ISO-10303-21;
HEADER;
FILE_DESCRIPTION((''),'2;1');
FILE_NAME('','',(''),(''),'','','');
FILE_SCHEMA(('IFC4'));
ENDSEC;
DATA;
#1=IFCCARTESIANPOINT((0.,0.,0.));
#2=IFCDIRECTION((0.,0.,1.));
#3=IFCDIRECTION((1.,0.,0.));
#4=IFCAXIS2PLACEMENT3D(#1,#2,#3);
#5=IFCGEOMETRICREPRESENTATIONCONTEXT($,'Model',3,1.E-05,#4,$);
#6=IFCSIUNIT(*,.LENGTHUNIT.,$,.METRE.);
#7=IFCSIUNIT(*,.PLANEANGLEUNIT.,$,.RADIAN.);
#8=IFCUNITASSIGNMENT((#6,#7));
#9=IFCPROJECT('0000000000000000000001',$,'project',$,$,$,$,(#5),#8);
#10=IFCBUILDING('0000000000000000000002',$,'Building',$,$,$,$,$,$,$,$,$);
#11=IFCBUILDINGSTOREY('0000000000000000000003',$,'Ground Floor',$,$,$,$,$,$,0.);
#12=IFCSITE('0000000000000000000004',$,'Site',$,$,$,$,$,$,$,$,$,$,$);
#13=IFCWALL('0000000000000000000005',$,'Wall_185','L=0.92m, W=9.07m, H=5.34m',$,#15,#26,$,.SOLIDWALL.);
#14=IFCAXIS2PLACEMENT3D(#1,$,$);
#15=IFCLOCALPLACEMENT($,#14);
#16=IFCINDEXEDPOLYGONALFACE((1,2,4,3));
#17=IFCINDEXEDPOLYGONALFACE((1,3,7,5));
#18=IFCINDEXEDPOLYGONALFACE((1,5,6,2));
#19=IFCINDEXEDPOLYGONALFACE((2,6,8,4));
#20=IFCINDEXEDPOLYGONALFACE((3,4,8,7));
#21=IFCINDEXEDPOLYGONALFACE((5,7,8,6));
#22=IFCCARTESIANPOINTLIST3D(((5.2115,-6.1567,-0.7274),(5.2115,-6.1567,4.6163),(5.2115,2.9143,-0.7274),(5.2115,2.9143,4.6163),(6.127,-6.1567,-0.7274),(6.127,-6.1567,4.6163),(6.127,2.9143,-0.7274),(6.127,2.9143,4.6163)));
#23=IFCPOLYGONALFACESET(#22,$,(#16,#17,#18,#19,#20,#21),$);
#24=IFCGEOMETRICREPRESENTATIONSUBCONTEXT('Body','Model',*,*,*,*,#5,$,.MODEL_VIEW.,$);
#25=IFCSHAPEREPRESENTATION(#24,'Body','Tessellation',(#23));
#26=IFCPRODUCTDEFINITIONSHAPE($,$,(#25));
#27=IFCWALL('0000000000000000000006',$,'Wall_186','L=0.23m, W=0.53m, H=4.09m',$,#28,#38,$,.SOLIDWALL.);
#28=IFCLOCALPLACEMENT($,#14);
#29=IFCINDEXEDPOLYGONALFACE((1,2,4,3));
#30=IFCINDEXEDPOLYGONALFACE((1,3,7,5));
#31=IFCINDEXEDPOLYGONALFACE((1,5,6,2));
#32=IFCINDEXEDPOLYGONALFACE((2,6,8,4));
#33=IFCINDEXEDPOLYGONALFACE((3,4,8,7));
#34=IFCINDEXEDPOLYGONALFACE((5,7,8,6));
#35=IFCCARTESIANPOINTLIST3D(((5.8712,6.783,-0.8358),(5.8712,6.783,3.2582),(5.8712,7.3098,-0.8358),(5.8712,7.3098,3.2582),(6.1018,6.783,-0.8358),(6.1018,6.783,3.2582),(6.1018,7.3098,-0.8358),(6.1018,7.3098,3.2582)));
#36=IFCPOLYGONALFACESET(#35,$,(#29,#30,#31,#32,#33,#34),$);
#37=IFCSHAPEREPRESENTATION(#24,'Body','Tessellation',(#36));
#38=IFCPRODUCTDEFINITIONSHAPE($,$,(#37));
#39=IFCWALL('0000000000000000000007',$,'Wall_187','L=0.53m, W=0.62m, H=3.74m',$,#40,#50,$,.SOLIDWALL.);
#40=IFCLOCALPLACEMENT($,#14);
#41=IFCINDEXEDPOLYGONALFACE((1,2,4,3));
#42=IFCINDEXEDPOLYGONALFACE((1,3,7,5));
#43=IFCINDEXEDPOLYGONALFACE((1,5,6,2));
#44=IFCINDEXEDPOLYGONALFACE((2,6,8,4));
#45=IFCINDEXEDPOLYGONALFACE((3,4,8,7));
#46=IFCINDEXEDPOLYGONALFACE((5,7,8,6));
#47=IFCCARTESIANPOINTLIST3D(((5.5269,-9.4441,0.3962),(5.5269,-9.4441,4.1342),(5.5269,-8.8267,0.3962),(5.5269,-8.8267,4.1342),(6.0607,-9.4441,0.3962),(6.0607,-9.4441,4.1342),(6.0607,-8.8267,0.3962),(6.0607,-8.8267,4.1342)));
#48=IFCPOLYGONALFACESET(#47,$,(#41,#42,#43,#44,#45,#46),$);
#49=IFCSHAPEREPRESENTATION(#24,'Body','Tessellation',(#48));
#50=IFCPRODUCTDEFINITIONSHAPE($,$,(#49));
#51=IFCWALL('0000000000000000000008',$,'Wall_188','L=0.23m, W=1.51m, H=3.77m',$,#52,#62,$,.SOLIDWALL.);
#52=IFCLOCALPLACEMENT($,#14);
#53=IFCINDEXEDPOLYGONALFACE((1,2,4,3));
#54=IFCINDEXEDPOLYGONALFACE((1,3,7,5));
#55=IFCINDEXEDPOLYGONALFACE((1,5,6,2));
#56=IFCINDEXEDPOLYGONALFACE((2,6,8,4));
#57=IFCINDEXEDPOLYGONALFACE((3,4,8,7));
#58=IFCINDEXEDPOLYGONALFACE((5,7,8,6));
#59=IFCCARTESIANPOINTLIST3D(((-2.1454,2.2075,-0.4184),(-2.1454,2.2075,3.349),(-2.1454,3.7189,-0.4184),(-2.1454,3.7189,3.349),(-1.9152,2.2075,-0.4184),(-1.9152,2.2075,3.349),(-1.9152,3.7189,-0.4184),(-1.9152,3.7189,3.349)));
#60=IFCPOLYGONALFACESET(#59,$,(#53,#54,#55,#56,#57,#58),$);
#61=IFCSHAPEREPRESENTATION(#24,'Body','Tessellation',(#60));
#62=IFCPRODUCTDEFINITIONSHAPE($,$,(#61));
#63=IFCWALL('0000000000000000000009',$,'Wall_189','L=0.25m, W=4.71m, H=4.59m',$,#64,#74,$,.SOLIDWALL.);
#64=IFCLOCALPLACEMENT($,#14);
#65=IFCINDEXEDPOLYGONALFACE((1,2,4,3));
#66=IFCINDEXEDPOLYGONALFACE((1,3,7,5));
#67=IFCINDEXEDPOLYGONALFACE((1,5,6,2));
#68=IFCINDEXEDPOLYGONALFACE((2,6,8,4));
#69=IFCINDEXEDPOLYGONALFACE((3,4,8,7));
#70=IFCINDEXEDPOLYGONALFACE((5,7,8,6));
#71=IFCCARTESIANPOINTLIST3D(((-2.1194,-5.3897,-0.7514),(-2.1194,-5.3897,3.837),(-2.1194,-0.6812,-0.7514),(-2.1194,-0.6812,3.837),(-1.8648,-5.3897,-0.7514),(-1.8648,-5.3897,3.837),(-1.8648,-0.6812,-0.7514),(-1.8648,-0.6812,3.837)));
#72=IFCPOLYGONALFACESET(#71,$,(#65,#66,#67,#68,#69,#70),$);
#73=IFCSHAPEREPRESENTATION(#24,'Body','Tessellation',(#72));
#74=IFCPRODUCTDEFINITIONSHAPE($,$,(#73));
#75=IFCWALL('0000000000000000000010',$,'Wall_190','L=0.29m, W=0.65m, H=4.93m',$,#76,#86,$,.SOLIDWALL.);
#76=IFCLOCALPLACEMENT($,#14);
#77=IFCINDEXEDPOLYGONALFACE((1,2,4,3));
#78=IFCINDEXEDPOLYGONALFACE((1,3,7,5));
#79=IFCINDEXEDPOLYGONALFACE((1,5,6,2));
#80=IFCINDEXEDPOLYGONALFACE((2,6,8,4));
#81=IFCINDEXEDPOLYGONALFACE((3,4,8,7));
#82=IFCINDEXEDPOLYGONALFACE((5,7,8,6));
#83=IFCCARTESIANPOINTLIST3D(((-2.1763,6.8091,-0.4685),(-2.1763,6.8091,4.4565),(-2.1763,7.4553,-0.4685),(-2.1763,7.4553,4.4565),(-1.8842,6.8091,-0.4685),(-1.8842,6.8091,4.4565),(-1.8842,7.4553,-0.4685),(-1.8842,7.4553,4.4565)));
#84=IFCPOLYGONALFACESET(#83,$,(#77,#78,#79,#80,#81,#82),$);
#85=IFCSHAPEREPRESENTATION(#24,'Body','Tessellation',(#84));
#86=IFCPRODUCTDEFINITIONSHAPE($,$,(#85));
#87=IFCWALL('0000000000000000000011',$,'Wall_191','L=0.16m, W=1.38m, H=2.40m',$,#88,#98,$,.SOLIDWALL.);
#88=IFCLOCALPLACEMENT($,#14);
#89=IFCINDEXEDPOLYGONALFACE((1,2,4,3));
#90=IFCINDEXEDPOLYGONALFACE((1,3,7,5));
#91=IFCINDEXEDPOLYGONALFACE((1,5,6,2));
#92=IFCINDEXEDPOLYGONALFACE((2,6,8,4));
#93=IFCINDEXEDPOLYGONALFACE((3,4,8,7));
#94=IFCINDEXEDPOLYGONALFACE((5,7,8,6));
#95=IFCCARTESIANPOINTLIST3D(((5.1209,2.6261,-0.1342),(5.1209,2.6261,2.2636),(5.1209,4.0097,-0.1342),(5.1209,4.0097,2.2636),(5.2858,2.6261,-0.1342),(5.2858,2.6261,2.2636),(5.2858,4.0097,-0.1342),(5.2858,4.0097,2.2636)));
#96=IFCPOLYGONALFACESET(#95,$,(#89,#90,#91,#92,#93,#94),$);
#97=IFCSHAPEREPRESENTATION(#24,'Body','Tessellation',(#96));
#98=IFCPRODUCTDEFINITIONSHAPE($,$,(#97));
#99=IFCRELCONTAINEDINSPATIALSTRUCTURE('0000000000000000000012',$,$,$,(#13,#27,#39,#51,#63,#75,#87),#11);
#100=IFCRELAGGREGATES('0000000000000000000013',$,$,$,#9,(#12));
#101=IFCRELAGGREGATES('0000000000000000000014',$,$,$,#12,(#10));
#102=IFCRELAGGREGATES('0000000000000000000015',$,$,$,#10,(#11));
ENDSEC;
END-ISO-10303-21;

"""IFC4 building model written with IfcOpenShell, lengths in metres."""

from ifc_helpers import new_model, si_unit, frame, origin_with_axes, origin_2d, context, subcontext, project, spatial, rectangle, extrude, element, save


model = new_model("IFC4")

# Units and contexts
model_context = context("Model", 3, precision=1e-05, world=origin_with_axes())
body_context = subcontext(model_context, "Body", "Model", "MODEL_VIEW")
ifc_project = project(units=[si_unit("LENGTHUNIT", "METRE"), si_unit("PLANEANGLEUNIT", "RADIAN")], contexts=[model_context])

# Site, building, storey
site = spatial("IfcSite", under=ifc_project, Name="Site")
building = spatial("IfcBuilding", under=site, Name="Building")
storey = spatial("IfcBuildingStorey", under=building, Name="Ground Floor", Elevation=0.0)

# Walls
element("IfcWall", 1, inside=storey, Name="Wall_185", Description="L=0.92m, W=9.07m, H=5.34m", PredefinedType="SOLIDWALL", context=body_context, shape_type="SweptSolid", body=[
    extrude(rectangle(XDim=0.9155, YDim=9.071, at=origin_2d()), frame((5.6693, -1.6212, -0.7274), z_axis=(0.0, 0.0, 1.0), x_axis=(1.0, 0.0, 0.0)), (0.0, 0.0, 1.0), 5.3437),
])
element("IfcWall", 2, inside=storey, Name="Wall_186", Description="L=0.23m, W=0.53m, H=4.09m", PredefinedType="SOLIDWALL", context=body_context, shape_type="SweptSolid", body=[
    extrude(rectangle(XDim=0.2306, YDim=0.5269, at=origin_2d()), frame((5.9865, 7.0464, -0.8358), z_axis=(0.0, 0.0, 1.0), x_axis=(1.0, 0.0, 0.0)), (0.0, 0.0, 1.0), 4.0939),
])
element("IfcWall", 3, inside=storey, Name="Wall_187", Description="L=0.53m, W=0.62m, H=3.74m", PredefinedType="SOLIDWALL", context=body_context, shape_type="SweptSolid", body=[
    extrude(rectangle(XDim=0.5338, YDim=0.6175, at=origin_2d()), frame((5.7938, -9.1354, 0.3962), z_axis=(0.0, 0.0, 1.0), x_axis=(1.0, 0.0, 0.0)), (0.0, 0.0, 1.0), 3.738),
])
element("IfcWall", 4, inside=storey, Name="Wall_188", Description="L=0.23m, W=1.51m, H=3.77m", PredefinedType="SOLIDWALL", context=body_context, shape_type="SweptSolid", body=[
    extrude(rectangle(XDim=0.2303, YDim=1.5114, at=origin_2d()), frame((-2.0303, 2.9632, -0.4184), z_axis=(0.0, 0.0, 1.0), x_axis=(1.0, 0.0, 0.0)), (0.0, 0.0, 1.0), 3.7674),
])
element("IfcWall", 5, inside=storey, Name="Wall_189", Description="L=0.25m, W=4.71m, H=4.59m", PredefinedType="SOLIDWALL", context=body_context, shape_type="SweptSolid", body=[
    extrude(rectangle(XDim=0.2547, YDim=4.7085, at=origin_2d()), frame((-1.9921, -3.0354, -0.7514), z_axis=(0.0, 0.0, 1.0), x_axis=(1.0, 0.0, 0.0)), (0.0, 0.0, 1.0), 4.5884),
])
element("IfcWall", 6, inside=storey, Name="Wall_190", Description="L=0.29m, W=0.65m, H=4.93m", PredefinedType="SOLIDWALL", context=body_context, shape_type="SweptSolid", body=[
    extrude(rectangle(XDim=0.2921, YDim=0.6462, at=origin_2d()), frame((-2.0302, 7.1322, -0.4685), z_axis=(0.0, 0.0, 1.0), x_axis=(1.0, 0.0, 0.0)), (0.0, 0.0, 1.0), 4.925),
])
element("IfcWall", 7, inside=storey, Name="Wall_191", Description="L=0.16m, W=1.38m, H=2.40m", PredefinedType="SOLIDWALL", context=body_context, shape_type="SweptSolid", body=[
    extrude(rectangle(XDim=0.1648, YDim=1.3836, at=origin_2d()), frame((5.2034, 3.3179, -0.1342), z_axis=(0.0, 0.0, 1.0), x_axis=(1.0, 0.0, 0.0)), (0.0, 0.0, 1.0), 2.3978),
])

save(model, "model.ifc")
